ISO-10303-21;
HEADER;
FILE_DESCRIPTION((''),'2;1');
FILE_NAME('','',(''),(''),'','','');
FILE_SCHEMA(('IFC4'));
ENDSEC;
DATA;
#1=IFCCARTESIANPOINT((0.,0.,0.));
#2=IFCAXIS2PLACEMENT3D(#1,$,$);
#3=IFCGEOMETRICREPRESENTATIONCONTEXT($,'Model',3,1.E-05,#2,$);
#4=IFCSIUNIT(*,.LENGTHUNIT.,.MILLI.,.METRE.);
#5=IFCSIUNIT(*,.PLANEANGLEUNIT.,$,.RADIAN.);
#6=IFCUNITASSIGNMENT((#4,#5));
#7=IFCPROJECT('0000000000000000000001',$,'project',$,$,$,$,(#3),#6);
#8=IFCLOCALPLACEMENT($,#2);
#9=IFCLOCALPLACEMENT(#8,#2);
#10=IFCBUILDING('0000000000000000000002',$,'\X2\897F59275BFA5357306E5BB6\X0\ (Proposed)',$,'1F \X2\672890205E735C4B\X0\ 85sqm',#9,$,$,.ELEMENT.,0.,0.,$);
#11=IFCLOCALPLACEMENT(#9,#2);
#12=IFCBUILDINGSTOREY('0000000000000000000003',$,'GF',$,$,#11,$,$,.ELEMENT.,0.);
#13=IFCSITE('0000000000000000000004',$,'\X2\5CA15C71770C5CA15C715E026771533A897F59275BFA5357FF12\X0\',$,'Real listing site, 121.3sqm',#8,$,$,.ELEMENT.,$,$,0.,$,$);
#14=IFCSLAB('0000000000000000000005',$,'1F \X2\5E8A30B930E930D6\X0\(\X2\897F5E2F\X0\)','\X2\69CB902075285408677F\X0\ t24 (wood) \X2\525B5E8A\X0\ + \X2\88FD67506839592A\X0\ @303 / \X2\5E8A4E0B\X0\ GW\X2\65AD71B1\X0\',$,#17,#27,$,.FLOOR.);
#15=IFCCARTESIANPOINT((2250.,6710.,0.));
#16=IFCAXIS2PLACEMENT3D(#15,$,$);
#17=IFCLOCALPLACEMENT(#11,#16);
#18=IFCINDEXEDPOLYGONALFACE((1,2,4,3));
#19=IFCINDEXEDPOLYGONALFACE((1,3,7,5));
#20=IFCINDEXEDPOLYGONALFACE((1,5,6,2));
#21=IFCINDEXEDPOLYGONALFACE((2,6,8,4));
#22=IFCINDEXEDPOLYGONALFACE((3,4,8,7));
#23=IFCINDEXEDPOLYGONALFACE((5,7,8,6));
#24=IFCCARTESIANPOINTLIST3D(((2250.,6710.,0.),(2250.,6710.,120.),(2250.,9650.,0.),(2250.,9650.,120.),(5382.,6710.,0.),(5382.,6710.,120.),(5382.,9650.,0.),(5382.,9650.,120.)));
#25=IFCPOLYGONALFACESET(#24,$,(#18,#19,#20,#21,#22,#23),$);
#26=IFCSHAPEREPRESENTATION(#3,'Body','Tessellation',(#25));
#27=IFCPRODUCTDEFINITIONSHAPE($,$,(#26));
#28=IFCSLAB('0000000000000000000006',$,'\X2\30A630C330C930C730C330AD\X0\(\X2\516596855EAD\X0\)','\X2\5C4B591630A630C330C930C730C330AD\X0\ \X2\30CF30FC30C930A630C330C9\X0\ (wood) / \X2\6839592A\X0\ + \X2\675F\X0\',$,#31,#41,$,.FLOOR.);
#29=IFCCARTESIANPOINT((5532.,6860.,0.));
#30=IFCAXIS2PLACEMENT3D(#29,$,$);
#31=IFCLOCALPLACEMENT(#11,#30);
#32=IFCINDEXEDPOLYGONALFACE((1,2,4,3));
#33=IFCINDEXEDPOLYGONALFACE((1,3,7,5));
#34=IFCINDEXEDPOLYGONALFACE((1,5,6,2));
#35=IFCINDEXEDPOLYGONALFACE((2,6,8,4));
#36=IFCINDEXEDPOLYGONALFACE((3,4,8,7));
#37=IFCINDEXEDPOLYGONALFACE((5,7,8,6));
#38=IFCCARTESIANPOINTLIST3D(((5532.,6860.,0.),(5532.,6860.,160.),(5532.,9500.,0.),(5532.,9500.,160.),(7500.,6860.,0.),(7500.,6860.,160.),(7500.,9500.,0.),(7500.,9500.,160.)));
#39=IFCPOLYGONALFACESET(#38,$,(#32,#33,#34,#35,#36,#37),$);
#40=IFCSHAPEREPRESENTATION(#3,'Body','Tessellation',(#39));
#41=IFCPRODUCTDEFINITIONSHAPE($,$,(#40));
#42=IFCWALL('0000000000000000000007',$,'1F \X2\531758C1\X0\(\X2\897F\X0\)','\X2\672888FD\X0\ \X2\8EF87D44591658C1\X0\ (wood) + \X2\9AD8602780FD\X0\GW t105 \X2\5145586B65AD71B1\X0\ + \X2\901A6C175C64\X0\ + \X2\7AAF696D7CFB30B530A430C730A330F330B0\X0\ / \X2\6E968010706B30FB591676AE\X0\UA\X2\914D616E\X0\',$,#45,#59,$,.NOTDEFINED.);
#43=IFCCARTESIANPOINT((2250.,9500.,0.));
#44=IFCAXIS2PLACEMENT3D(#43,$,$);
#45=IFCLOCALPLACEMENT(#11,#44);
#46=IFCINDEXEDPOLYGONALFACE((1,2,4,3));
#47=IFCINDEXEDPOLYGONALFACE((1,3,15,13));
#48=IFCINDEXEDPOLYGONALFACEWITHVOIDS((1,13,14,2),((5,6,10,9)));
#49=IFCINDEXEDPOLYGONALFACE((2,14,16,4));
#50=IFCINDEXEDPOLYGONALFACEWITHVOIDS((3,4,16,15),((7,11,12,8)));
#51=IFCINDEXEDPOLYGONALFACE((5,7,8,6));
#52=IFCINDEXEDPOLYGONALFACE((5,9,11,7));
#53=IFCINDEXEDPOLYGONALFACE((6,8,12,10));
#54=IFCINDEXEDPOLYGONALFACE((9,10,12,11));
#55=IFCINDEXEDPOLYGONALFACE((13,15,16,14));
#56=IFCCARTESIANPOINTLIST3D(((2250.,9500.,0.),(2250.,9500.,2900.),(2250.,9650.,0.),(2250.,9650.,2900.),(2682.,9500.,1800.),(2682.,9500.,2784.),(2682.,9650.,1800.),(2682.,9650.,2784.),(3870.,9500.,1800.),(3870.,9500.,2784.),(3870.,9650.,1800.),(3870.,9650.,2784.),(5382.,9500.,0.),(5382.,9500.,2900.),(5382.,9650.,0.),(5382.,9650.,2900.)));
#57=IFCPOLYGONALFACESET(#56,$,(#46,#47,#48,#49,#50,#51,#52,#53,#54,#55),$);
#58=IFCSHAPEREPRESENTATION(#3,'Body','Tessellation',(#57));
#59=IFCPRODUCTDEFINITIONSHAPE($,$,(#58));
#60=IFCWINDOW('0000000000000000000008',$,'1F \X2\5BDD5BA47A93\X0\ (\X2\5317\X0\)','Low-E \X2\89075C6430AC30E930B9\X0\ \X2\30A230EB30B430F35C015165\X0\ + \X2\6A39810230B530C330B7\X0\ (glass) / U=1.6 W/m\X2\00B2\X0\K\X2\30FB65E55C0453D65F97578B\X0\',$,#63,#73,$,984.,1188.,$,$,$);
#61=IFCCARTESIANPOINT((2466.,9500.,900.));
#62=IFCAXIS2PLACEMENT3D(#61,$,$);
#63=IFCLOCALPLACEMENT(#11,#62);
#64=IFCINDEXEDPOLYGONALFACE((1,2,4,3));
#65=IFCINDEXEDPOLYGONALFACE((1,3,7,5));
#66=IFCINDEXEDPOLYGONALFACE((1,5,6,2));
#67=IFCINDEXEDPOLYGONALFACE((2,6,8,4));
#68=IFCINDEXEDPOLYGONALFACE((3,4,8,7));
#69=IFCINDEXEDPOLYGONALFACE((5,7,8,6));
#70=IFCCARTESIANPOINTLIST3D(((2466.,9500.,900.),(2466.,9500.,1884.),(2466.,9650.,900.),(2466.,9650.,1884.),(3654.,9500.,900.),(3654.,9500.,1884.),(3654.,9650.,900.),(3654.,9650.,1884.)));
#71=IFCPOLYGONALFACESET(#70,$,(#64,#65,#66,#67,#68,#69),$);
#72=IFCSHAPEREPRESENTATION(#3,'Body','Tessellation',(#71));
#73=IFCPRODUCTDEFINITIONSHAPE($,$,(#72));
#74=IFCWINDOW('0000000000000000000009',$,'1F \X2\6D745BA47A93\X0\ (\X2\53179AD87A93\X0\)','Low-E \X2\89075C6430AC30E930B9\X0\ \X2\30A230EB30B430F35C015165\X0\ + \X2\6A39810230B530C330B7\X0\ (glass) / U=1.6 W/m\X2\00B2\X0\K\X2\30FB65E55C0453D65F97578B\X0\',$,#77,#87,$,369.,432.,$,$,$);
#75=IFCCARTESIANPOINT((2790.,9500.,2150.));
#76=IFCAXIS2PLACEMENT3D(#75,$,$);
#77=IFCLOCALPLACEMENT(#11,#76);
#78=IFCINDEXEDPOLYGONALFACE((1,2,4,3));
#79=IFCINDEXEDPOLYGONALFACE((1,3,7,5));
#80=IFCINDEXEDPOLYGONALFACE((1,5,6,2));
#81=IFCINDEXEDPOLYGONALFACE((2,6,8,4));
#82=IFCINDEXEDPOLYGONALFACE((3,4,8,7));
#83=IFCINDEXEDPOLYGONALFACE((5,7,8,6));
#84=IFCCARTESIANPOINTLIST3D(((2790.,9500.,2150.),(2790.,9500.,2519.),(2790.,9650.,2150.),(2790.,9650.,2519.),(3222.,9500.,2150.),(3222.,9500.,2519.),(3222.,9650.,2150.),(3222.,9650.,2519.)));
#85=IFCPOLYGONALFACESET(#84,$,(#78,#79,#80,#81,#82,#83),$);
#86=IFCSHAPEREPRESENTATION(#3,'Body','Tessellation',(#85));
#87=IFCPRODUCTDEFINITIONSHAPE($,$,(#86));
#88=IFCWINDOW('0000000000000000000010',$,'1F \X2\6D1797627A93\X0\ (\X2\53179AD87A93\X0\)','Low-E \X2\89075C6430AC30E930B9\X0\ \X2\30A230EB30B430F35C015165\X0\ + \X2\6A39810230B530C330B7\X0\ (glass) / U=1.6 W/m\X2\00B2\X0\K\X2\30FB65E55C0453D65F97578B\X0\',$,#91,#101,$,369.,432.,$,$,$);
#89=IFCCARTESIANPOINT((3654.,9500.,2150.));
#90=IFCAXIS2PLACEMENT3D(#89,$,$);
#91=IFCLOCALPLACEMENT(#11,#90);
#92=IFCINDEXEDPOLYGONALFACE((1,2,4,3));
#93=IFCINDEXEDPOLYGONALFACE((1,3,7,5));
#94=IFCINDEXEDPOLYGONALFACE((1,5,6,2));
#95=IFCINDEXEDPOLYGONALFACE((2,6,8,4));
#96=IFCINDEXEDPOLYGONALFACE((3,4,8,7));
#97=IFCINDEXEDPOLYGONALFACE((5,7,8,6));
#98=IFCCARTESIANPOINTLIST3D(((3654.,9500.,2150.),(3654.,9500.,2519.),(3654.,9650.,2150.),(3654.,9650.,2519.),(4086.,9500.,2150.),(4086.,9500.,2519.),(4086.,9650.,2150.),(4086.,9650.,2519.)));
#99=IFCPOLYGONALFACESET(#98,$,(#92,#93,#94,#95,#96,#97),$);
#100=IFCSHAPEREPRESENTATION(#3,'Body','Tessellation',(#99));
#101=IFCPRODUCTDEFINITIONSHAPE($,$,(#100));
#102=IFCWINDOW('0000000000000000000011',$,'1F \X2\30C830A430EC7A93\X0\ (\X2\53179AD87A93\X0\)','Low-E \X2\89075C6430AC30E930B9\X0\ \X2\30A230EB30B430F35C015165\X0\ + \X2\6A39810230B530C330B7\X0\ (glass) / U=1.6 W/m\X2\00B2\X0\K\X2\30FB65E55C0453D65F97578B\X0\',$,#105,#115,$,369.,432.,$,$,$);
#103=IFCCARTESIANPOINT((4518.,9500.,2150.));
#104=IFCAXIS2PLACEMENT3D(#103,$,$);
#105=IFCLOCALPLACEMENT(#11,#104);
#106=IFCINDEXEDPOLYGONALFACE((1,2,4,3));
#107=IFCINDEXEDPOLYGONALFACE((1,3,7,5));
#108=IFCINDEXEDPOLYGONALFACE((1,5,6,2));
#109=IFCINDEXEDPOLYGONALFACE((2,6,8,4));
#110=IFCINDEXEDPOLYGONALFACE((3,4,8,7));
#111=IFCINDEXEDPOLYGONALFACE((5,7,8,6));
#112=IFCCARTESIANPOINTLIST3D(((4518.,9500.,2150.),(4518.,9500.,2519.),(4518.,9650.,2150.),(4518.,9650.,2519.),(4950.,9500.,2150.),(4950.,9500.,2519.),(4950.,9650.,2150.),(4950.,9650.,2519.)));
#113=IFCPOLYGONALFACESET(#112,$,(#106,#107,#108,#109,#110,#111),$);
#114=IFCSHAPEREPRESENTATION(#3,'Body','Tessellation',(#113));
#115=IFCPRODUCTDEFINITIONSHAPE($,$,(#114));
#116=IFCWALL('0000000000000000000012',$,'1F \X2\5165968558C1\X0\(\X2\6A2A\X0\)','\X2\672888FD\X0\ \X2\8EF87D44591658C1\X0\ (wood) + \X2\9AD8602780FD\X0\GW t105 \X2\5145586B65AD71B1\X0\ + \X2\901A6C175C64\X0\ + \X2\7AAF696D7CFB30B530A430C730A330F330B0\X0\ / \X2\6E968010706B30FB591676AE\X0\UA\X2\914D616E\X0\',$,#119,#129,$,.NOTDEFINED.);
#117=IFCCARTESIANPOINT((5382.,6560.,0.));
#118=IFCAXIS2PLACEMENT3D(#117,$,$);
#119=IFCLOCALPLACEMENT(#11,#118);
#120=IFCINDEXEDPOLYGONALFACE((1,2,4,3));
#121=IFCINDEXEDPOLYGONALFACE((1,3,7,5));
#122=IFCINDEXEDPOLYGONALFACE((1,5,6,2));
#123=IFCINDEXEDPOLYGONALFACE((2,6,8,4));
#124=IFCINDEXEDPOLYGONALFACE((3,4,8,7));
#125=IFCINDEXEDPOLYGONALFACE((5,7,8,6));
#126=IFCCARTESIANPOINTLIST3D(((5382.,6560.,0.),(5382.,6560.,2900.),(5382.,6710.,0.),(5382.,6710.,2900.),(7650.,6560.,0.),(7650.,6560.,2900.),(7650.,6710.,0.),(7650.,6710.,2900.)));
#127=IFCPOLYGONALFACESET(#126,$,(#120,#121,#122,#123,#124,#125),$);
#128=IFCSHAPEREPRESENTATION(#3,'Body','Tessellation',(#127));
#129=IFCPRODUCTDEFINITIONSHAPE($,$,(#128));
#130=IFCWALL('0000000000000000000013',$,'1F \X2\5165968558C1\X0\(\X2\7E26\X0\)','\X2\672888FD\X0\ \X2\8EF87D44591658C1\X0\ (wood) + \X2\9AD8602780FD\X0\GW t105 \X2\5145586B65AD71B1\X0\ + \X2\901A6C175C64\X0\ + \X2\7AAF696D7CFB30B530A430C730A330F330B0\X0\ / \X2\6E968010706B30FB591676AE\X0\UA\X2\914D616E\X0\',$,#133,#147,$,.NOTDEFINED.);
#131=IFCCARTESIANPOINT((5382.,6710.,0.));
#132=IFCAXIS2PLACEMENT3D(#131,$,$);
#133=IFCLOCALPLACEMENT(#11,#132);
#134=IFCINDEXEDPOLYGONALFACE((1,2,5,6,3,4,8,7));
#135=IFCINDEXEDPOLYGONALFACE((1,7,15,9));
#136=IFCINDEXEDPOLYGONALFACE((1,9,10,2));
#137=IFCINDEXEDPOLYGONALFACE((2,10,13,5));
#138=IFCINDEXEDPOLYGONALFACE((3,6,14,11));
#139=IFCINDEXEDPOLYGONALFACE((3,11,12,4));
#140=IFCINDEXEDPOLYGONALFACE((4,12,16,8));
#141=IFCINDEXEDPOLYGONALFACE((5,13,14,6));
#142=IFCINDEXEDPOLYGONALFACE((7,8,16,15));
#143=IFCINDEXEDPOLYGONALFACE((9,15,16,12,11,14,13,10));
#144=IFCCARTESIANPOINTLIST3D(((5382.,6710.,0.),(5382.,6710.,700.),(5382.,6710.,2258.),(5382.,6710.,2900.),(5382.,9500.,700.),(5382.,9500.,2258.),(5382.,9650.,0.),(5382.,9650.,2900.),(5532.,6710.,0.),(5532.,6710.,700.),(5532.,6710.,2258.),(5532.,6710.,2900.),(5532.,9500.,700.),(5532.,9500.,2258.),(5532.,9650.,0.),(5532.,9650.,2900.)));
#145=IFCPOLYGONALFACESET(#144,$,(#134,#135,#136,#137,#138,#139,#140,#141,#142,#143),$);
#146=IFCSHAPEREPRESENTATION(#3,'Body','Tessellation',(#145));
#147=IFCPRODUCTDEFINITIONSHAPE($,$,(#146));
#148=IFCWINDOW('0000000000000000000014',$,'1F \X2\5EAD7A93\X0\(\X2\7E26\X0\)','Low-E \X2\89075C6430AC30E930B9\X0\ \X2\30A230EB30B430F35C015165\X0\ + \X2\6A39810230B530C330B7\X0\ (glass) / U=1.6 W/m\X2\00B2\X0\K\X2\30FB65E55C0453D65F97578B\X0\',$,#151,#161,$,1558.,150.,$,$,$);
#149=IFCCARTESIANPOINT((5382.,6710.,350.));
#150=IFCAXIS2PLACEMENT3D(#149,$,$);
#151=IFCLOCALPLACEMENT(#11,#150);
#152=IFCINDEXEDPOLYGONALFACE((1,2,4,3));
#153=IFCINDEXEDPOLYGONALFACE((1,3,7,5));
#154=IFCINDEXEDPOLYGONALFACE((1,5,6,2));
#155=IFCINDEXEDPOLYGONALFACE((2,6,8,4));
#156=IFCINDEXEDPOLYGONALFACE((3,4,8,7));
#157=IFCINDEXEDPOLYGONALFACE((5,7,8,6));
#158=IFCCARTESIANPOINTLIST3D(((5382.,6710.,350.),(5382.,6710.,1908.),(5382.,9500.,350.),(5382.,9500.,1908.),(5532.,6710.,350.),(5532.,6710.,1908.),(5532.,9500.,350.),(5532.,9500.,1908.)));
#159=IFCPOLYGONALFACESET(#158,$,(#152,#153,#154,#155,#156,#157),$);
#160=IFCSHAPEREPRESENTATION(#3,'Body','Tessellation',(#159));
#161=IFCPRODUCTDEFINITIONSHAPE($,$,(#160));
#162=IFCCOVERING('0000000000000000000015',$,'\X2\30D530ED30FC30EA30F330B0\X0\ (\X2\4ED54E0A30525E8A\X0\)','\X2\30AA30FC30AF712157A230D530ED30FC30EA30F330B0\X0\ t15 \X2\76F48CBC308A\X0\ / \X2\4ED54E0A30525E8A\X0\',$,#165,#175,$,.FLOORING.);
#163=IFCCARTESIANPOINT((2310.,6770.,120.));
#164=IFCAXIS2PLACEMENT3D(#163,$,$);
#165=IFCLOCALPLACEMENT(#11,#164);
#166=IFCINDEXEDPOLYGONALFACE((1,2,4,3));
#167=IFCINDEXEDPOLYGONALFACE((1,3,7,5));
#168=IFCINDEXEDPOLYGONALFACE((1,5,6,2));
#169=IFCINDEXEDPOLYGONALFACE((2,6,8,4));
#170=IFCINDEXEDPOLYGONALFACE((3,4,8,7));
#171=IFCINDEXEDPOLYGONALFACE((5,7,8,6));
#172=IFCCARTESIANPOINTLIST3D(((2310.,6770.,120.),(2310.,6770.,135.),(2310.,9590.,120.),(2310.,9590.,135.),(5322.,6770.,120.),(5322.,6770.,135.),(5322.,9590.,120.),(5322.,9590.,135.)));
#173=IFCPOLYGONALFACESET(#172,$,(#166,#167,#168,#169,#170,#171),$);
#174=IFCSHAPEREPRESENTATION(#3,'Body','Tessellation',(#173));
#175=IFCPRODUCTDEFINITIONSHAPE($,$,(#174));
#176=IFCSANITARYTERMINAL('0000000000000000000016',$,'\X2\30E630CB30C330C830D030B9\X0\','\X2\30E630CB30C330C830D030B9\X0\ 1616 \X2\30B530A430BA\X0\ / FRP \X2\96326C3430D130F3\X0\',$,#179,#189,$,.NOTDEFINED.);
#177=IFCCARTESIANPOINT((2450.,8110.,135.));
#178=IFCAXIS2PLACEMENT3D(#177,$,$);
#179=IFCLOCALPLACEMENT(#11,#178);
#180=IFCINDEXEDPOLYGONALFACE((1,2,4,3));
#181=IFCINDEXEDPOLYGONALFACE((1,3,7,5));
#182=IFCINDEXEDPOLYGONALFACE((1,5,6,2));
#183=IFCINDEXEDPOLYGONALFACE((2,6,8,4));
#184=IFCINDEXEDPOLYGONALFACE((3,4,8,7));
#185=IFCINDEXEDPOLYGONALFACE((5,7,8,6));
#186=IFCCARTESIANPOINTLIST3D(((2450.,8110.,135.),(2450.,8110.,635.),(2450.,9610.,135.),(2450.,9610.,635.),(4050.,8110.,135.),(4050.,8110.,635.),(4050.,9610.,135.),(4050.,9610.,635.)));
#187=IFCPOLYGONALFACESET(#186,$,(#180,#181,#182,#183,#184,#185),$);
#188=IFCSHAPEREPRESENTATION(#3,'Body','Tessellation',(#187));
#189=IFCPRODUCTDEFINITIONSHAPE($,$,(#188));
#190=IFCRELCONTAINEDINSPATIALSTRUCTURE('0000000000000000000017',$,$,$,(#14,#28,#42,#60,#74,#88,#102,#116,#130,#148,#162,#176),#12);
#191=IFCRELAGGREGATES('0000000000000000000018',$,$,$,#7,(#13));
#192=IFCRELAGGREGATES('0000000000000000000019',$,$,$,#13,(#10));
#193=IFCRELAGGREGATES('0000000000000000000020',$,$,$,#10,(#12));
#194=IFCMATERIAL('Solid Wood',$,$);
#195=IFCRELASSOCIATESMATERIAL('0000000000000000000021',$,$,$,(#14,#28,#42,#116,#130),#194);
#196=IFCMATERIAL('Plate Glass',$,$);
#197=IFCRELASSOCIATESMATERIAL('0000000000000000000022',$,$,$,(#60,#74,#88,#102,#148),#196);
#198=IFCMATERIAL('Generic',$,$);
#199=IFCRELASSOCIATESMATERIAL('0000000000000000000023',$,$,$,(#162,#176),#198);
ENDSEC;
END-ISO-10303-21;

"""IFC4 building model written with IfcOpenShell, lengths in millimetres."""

from ifc_helpers import new_model, si_unit, frame, frame_2d, origin, place, context, project, spatial, rectangle, extrude, material, element, fill, save


model = new_model("IFC4")

# Units and contexts
model_context = context("Model", 3, precision=1e-05, world=origin())
ifc_project = project(units=[si_unit("LENGTHUNIT", "METRE", prefix="MILLI"), si_unit("PLANEANGLEUNIT", "RADIAN")], contexts=[model_context])

# Site, building, storey
site_placement = place(None, origin())
site = spatial("IfcSite", under=ifc_project, at=site_placement, Name="岡山県岡山市東区西大寺南２", ObjectType="Real listing site, 121.3sqm", CompositionType="ELEMENT", RefElevation=0.0)
building_placement = place(site_placement, origin())
building = spatial("IfcBuilding", under=site, at=building_placement, Name="西大寺南の家 (Proposed)", ObjectType="1F 木造平屋 85sqm", CompositionType="ELEMENT", ElevationOfRefHeight=0.0, ElevationOfTerrain=0.0)
storey_placement = place(building_placement, origin())
storey = spatial("IfcBuildingStorey", under=building, at=storey_placement, Name="GF", CompositionType="ELEMENT", Elevation=0.0)

# Slabs
ifc_material_1 = material(Name="Solid Wood")
slab_1_placement = place(storey_placement, frame((2250.0, 6710.0, 0.0)))
element("IfcSlab", 1, at=slab_1_placement, inside=storey, material=ifc_material_1, Name="1F 床スラブ(西帯)", Description="構造用合板 t24 (wood) 剛床 + 製材根太 @303 / 床下 GW断熱", PredefinedType="FLOOR", context=model_context, shape_type="SweptSolid", body=[
    extrude(rectangle(XDim=3132.0, YDim=2940.0, at=frame_2d((1566.0, 1470.0))), frame((2250.0, 6710.0, 0.0)), (0.0, 0.0, 1.0), 120.0),
])
slab_2_placement = place(storey_placement, frame((5532.0, 6860.0, 0.0)))
element("IfcSlab", 2, at=slab_2_placement, inside=storey, material=ifc_material_1, Name="ウッドデッキ(入隅庭)", Description="屋外ウッドデッキ ハードウッド (wood) / 根太 + 束", PredefinedType="FLOOR", context=model_context, shape_type="SweptSolid", body=[
    extrude(rectangle(XDim=1968.0, YDim=2640.0, at=frame_2d((984.0, 1320.0))), frame((5532.0, 6860.0, 0.0)), (0.0, 0.0, 1.0), 160.0),
])

# Wall, openings, windows
wall_1_placement = place(storey_placement, frame((2250.0, 9500.0, 0.0)))
wall_1 = element("IfcWall", 3, at=wall_1_placement, inside=storey, material=ifc_material_1, Name="1F 北壁(西)", Description="木製 軸組外壁 (wood) + 高性能GW t105 充填断熱 + 通気層 + 窯業系サイディング / 準耐火・外皮UA配慮", PredefinedType="NOTDEFINED", context=model_context, shape_type="SweptSolid", body=[
    extrude(rectangle(XDim=3132.0, YDim=150.0, at=frame_2d((1566.0, 75.0))), frame((2250.0, 9500.0, 0.0)), (0.0, 0.0, 1.0), 2900.0),
])
opening_1_placement = place(storey_placement, frame((2466.0, 9500.0, 900.0)))
opening_1 = element("IfcOpeningElement", 4, at=opening_1_placement, cuts=wall_1, PredefinedType="NOTDEFINED", context=model_context, shape_type="SweptSolid", body=[
    extrude(rectangle(XDim=1188.0, YDim=150.0, at=frame_2d((594.0, 75.0))), frame((2466.0, 9500.0, 900.0)), (0.0, 0.0, 1.0), 984.0),
])
opening_2_placement = place(storey_placement, frame((2790.0, 9500.0, 2150.0)))
opening_2 = element("IfcOpeningElement", 5, at=opening_2_placement, cuts=wall_1, PredefinedType="NOTDEFINED", context=model_context, shape_type="SweptSolid", body=[
    extrude(rectangle(XDim=432.0, YDim=150.0, at=frame_2d((216.0, 75.0))), frame((2790.0, 9500.0, 2150.0)), (0.0, 0.0, 1.0), 369.0),
])
opening_3_placement = place(storey_placement, frame((3654.0, 9500.0, 2150.0)))
opening_3 = element("IfcOpeningElement", 6, at=opening_3_placement, cuts=wall_1, PredefinedType="NOTDEFINED", context=model_context, shape_type="SweptSolid", body=[
    extrude(rectangle(XDim=432.0, YDim=150.0, at=frame_2d((216.0, 75.0))), frame((3654.0, 9500.0, 2150.0)), (0.0, 0.0, 1.0), 369.0),
])
opening_4_placement = place(storey_placement, frame((4518.0, 9500.0, 2150.0)))
opening_4 = element("IfcOpeningElement", 7, at=opening_4_placement, cuts=wall_1, PredefinedType="NOTDEFINED", context=model_context, shape_type="SweptSolid", body=[
    extrude(rectangle(XDim=432.0, YDim=150.0, at=frame_2d((216.0, 75.0))), frame((4518.0, 9500.0, 2150.0)), (0.0, 0.0, 1.0), 369.0),
])
ifc_material_2 = material(Name="Plate Glass")
window_1_placement = place(storey_placement, frame((2466.0, 9500.0, 900.0)))
window_1 = element("IfcWindow", 8, at=window_1_placement, inside=storey, material=ifc_material_2, Name="1F 寝室窓 (北)", Description="Low-E 複層ガラス アルゴン封入 + 樹脂サッシ (glass) / U=1.6 W/m²K・日射取得型", OverallHeight=984.0, OverallWidth=1188.0, context=model_context, shape_type="SweptSolid", body=[
    extrude(rectangle(XDim=1188.0, YDim=150.0, at=frame_2d((594.0, 75.0))), frame((2466.0, 9500.0, 900.0)), (0.0, 0.0, 1.0), 984.0),
])
fill(opening_1, window_1)
window_2_placement = place(storey_placement, frame((2790.0, 9500.0, 2150.0)))
window_2 = element("IfcWindow", 9, at=window_2_placement, inside=storey, material=ifc_material_2, Name="1F 浴室窓 (北高窓)", Description="Low-E 複層ガラス アルゴン封入 + 樹脂サッシ (glass) / U=1.6 W/m²K・日射取得型", OverallHeight=369.0, OverallWidth=432.0, context=model_context, shape_type="SweptSolid", body=[
    extrude(rectangle(XDim=432.0, YDim=150.0, at=frame_2d((216.0, 75.0))), frame((2790.0, 9500.0, 2150.0)), (0.0, 0.0, 1.0), 369.0),
])
fill(opening_2, window_2)
window_3_placement = place(storey_placement, frame((3654.0, 9500.0, 2150.0)))
window_3 = element("IfcWindow", 10, at=window_3_placement, inside=storey, material=ifc_material_2, Name="1F 洗面窓 (北高窓)", Description="Low-E 複層ガラス アルゴン封入 + 樹脂サッシ (glass) / U=1.6 W/m²K・日射取得型", OverallHeight=369.0, OverallWidth=432.0, context=model_context, shape_type="SweptSolid", body=[
    extrude(rectangle(XDim=432.0, YDim=150.0, at=frame_2d((216.0, 75.0))), frame((3654.0, 9500.0, 2150.0)), (0.0, 0.0, 1.0), 369.0),
])
fill(opening_3, window_3)
window_4_placement = place(storey_placement, frame((4518.0, 9500.0, 2150.0)))
window_4 = element("IfcWindow", 11, at=window_4_placement, inside=storey, material=ifc_material_2, Name="1F トイレ窓 (北高窓)", Description="Low-E 複層ガラス アルゴン封入 + 樹脂サッシ (glass) / U=1.6 W/m²K・日射取得型", OverallHeight=369.0, OverallWidth=432.0, context=model_context, shape_type="SweptSolid", body=[
    extrude(rectangle(XDim=432.0, YDim=150.0, at=frame_2d((216.0, 75.0))), frame((4518.0, 9500.0, 2150.0)), (0.0, 0.0, 1.0), 369.0),
])
fill(opening_4, window_4)

# Wall
wall_2_placement = place(storey_placement, frame((5382.0, 6560.0, 0.0)))
element("IfcWall", 12, at=wall_2_placement, inside=storey, material=ifc_material_1, Name="1F 入隅壁(横)", Description="木製 軸組外壁 (wood) + 高性能GW t105 充填断熱 + 通気層 + 窯業系サイディング / 準耐火・外皮UA配慮", PredefinedType="NOTDEFINED", context=model_context, shape_type="SweptSolid", body=[
    extrude(rectangle(XDim=2268.0, YDim=150.0, at=frame_2d((1134.0, 75.0))), frame((5382.0, 6560.0, 0.0)), (0.0, 0.0, 1.0), 2900.0),
])

# Wall, opening, window
wall_3_placement = place(storey_placement, frame((5382.0, 6710.0, 0.0)))
wall_3 = element("IfcWall", 13, at=wall_3_placement, inside=storey, material=ifc_material_1, Name="1F 入隅壁(縦)", Description="木製 軸組外壁 (wood) + 高性能GW t105 充填断熱 + 通気層 + 窯業系サイディング / 準耐火・外皮UA配慮", PredefinedType="NOTDEFINED", context=model_context, shape_type="SweptSolid", body=[
    extrude(rectangle(XDim=150.0, YDim=2940.0, at=frame_2d((75.0, 1470.0))), frame((5382.0, 6710.0, 0.0)), (0.0, 0.0, 1.0), 2900.0),
])
opening_5_placement = place(storey_placement, frame((5382.0, 6710.0, 350.0)))
opening_5 = element("IfcOpeningElement", 14, at=opening_5_placement, cuts=wall_3, PredefinedType="NOTDEFINED", context=model_context, shape_type="SweptSolid", body=[
    extrude(rectangle(XDim=150.0, YDim=2790.0, at=frame_2d((75.0, 1395.0))), frame((5382.0, 6710.0, 350.0)), (0.0, 0.0, 1.0), 1558.0),
])
window_5_placement = place(storey_placement, frame((5382.0, 6710.0, 350.0)))
window_5 = element("IfcWindow", 15, at=window_5_placement, inside=storey, material=ifc_material_2, Name="1F 庭窓(縦)", Description="Low-E 複層ガラス アルゴン封入 + 樹脂サッシ (glass) / U=1.6 W/m²K・日射取得型", OverallHeight=1558.0, OverallWidth=150.0, context=model_context, shape_type="SweptSolid", body=[
    extrude(rectangle(XDim=150.0, YDim=2790.0, at=frame_2d((75.0, 1395.0))), frame((5382.0, 6710.0, 350.0)), (0.0, 0.0, 1.0), 1558.0),
])
fill(opening_5, window_5)

# Covering
ifc_material_3 = material(Name="Generic")
covering_placement = place(storey_placement, frame((2310.0, 6770.0, 120.0)))
element("IfcCovering", 16, at=covering_placement, inside=storey, material=ifc_material_3, Name="フローリング (仕上げ床)", Description="オーク無垢フローリング t15 直貼り / 仕上げ床", PredefinedType="FLOORING", context=model_context, shape_type="SweptSolid", body=[
    extrude(rectangle(XDim=3012.0, YDim=2820.0, at=frame_2d((1506.0, 1410.0))), frame((2310.0, 6770.0, 120.0)), (0.0, 0.0, 1.0), 15.0),
])

# Sanitary terminal
sanitary_terminal_1_placement = place(storey_placement, frame((2450.0, 8110.0, 135.0)))
element("IfcSanitaryTerminal", 17, at=sanitary_terminal_1_placement, inside=storey, material=ifc_material_3, Name="ユニットバス", Description="ユニットバス 1616 サイズ / FRP 防水パン", PredefinedType="NOTDEFINED", context=model_context, shape_type="SweptSolid", body=[
    extrude(rectangle(XDim=1600.0, YDim=1500.0, at=frame_2d((800.0, 750.0))), frame((2450.0, 8110.0, 135.0)), (0.0, 0.0, 1.0), 500.0),
])

save(model, "model.ifc")
